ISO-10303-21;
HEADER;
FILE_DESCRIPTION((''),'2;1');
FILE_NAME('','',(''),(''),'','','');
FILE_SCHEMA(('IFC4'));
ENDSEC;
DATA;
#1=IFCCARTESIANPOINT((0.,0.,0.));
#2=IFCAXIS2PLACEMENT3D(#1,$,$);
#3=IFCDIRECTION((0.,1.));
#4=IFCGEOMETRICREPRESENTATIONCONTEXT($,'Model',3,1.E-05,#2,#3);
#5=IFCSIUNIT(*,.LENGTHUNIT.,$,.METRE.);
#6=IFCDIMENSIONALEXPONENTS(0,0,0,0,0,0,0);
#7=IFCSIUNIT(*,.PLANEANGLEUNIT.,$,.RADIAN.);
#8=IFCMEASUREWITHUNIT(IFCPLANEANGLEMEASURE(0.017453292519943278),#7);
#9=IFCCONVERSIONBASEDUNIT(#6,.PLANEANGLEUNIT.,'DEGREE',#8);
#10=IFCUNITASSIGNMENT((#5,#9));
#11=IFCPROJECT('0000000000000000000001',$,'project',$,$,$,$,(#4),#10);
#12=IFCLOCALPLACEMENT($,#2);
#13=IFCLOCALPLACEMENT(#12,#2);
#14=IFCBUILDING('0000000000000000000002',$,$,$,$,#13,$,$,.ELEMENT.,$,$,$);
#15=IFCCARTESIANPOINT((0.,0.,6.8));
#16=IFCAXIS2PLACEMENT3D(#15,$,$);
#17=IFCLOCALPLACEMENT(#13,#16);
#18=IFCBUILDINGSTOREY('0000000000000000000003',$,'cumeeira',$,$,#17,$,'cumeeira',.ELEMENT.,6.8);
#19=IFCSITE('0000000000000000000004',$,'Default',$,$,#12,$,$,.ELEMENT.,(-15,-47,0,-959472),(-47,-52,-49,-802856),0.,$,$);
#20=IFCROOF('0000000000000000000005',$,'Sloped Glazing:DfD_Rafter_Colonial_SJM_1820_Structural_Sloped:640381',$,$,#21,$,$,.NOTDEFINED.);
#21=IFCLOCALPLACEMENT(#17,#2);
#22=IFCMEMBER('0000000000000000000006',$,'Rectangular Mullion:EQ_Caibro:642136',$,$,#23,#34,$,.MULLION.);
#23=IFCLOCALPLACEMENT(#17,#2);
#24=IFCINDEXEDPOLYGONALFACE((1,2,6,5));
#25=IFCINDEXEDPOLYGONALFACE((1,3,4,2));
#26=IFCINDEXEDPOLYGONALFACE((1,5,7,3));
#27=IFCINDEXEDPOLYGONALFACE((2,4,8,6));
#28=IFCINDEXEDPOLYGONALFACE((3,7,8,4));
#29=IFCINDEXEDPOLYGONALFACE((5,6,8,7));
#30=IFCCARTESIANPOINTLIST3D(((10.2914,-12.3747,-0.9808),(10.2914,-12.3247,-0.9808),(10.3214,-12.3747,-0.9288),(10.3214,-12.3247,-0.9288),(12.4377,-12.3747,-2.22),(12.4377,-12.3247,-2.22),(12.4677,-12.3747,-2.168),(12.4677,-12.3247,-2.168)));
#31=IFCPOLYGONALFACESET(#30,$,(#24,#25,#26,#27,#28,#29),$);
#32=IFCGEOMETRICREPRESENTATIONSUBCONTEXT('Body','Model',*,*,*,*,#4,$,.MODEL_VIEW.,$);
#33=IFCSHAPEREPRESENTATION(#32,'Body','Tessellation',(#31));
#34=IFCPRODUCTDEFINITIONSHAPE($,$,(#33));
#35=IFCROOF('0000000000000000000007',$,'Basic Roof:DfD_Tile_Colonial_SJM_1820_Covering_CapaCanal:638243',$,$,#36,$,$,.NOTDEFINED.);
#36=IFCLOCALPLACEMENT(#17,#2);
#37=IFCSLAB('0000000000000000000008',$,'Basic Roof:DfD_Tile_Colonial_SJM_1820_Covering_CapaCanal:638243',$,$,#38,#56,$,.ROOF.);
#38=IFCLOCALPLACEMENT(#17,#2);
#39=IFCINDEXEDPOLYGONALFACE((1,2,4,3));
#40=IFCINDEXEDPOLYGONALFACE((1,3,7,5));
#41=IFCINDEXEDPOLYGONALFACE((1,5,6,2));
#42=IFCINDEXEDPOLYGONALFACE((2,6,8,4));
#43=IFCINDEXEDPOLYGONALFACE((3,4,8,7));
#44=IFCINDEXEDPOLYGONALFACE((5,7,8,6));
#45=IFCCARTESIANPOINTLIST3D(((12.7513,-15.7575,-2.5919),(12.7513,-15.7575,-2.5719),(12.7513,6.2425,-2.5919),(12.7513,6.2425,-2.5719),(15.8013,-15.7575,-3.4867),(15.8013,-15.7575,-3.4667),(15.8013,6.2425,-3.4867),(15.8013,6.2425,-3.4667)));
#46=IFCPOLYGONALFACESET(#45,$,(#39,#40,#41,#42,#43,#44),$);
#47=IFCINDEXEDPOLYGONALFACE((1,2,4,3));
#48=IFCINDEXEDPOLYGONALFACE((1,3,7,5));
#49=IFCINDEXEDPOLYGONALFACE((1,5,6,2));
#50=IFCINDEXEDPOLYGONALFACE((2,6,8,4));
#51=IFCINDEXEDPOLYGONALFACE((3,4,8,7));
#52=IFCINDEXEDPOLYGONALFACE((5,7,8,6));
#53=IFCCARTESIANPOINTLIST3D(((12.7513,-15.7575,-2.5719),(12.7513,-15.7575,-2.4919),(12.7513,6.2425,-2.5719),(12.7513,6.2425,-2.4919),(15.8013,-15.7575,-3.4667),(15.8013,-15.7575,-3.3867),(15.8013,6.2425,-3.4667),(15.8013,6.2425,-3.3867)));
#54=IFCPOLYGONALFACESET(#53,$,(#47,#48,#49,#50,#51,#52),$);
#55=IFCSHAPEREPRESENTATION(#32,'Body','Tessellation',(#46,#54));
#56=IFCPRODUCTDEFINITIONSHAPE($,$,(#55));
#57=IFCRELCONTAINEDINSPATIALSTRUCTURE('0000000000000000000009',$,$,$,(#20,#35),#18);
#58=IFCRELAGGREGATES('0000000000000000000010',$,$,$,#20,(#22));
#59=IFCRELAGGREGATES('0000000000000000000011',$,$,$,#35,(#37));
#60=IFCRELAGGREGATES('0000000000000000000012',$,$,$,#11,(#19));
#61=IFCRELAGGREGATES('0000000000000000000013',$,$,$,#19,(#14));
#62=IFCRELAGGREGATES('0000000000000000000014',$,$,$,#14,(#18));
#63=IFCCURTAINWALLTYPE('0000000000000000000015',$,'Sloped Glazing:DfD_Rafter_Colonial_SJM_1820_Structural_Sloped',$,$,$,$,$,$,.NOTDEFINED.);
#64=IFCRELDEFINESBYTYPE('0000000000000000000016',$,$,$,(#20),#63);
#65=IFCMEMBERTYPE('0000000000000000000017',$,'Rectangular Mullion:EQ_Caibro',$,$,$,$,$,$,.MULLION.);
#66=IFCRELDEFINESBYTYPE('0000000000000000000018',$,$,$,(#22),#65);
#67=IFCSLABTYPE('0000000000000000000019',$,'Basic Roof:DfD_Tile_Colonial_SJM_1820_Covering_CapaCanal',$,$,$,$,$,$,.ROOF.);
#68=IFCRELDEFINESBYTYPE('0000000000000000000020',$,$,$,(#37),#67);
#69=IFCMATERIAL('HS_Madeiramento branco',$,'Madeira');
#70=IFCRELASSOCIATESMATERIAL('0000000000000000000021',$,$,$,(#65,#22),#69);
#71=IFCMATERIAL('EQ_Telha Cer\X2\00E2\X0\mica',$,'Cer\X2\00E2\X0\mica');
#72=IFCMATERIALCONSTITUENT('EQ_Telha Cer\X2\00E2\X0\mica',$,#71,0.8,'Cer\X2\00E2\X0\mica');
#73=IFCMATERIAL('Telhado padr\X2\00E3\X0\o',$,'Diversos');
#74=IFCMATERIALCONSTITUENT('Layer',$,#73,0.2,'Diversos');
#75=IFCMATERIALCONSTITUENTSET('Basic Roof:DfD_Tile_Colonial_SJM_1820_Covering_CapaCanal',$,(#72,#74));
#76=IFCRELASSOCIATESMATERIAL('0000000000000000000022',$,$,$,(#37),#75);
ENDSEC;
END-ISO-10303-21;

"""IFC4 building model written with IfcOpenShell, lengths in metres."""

from ifc_helpers import new_model, entity, si_unit, converted_unit, direction, frame, origin, place, context, subcontext, project, spatial, indexed_curve, outline, extrude, source, transform, mapped, material, constituent, constituent_set, type_object, type_shapes, element, aggregate, save


model = new_model("IFC4")

# Units and contexts
model_context = context("Model", 3, precision=1e-05, world=origin(), true_north=direction((0.0, 1.0)))
body_context = subcontext(model_context, "Body", "Model", "MODEL_VIEW")
ifc_project = project(units=[si_unit("LENGTHUNIT", "METRE"), converted_unit("PLANEANGLEUNIT", "DEGREE", entity("IfcPlaneAngleMeasure", 0.017453292519943278), si_unit("PLANEANGLEUNIT", "RADIAN"), dimensions=[0, 0, 0, 0, 0, 0, 0])], contexts=[model_context])

# Site, building, storey
site_placement = place(None, origin())
site = spatial("IfcSite", under=ifc_project, at=site_placement, Name="Default", CompositionType="ELEMENT", RefLatitude=(-15, -47, 0, -959472), RefLongitude=(-47, -52, -49, -802856), RefElevation=0.0)
building_placement = place(site_placement, origin())
building = spatial("IfcBuilding", under=site, at=building_placement, CompositionType="ELEMENT")
storey_placement = place(building_placement, frame((0.0, 0.0, 6.8)))
storey = spatial("IfcBuildingStorey", under=building, at=storey_placement, Name="cumeeira", LongName="cumeeira", CompositionType="ELEMENT", Elevation=6.8)

# Roof
curtain_wall_type_1 = type_object("IfcCurtainWallType", Name="Sloped Glazing:DfD_Rafter_Colonial_SJM_1820_Structural_Sloped", PredefinedType="NOTDEFINED")
roof_1_placement = place(storey_placement, frame((0.0, 0.0, -6.8)))
roof_1 = element("IfcRoof", 1, at=roof_1_placement, inside=storey, type_object=curtain_wall_type_1, Name="Sloped Glazing:DfD_Rafter_Colonial_SJM_1820_Structural_Sloped:640381", PredefinedType="NOTDEFINED")
ifc_material_1 = material(Name="HS_Madeiramento branco", Category="Madeira")

# Member
member_type_1 = type_object("IfcMemberType", Name="Rectangular Mullion:EQ_Caibro", PredefinedType="MULLION", material=ifc_material_1)
shared_shape_1 = source(origin(), body_context, "Body", "SweptSolid", [
    extrude(outline(indexed_curve([(-0.025, -0.03), (0.025, -0.03), (0.025, 0.03), (-0.025, 0.03), (-0.025, -0.03)], self_intersect=False)), frame((0.0, -0.03, -2.4784), z_axis=(0.0, 0.0, 1.0), x_axis=(-1.0, 0.0, 0.0)), (0.0, 0.0, 1.0), 2.4784),
])
type_shapes(member_type_1, [shared_shape_1])
member_1_placement = place(roof_1_placement, frame((10.2914, -12.3497, 5.8192), z_axis=(-0.866025, 0.0, 0.5), x_axis=(0.0, 1.0, 0.0)))
member_1 = element("IfcMember", 2, at=member_1_placement, type_object=member_type_1, material=ifc_material_1, Name="Rectangular Mullion:EQ_Caibro:642136", PredefinedType="MULLION", context=body_context, shape_type="MappedRepresentation", body=[
    mapped(shared_shape_1, transform((0.0, 0.0, 0.0), scale=1.0)),
])
aggregate(roof_1, [member_1])

# Roof, slab
roof_2_placement = place(storey_placement, frame((12.7513, -15.7575, -3.4867)))
roof_2 = element("IfcRoof", 3, at=roof_2_placement, inside=storey, Name="Basic Roof:DfD_Tile_Colonial_SJM_1820_Covering_CapaCanal:638243", PredefinedType="NOTDEFINED")
ifc_material_2 = material(Name="EQ_Telha Cerâmica", Category="Cerâmica")
ifc_constituent_1 = constituent(ifc_material_2, Name="EQ_Telha Cerâmica", Category="Cerâmica", fraction=0.8)
ifc_material_3 = material(Name="Telhado padrão", Category="Diversos")
ifc_constituent_2 = constituent(ifc_material_3, Name="Layer", Category="Diversos", fraction=0.2)
ifc_constituent_set = constituent_set(constituents=[ifc_constituent_1, ifc_constituent_2], Name="Basic Roof:DfD_Tile_Colonial_SJM_1820_Covering_CapaCanal")
slab_type = type_object("IfcSlabType", Name="Basic Roof:DfD_Tile_Colonial_SJM_1820_Covering_CapaCanal", PredefinedType="ROOF")
slab_placement = place(roof_2_placement, origin())
slab = element("IfcSlab", 4, at=slab_placement, type_object=slab_type, material=ifc_constituent_set, Name="Basic Roof:DfD_Tile_Colonial_SJM_1820_Covering_CapaCanal:638243", PredefinedType="ROOF", context=body_context, shape_type="SweptSolid", body=[
    extrude(outline(indexed_curve([(-1.5893, 11.0), (-1.5893, -11.0), (1.5893, -11.0), (1.5893, 11.0), (-1.5893, 11.0)], self_intersect=False)), frame((1.525, 11.0, 0.4474), z_axis=(0.281504, 0.0, 0.95956), x_axis=(0.95956, 0.0, -0.281504)), (-0.281504, 0.0, 0.95956), 0.02),
    extrude(outline(indexed_curve([(-1.5893, 11.0), (-1.5893, -11.0), (1.5893, -11.0), (1.5893, 11.0), (-1.5893, 11.0)], self_intersect=False)), frame((1.525, 11.0, 0.4674), z_axis=(0.281504, 0.0, 0.95956), x_axis=(0.95956, 0.0, -0.281504)), (-0.281504, 0.0, 0.95956), 0.08),
])
aggregate(roof_2, [slab])

save(model, "model.ifc")
